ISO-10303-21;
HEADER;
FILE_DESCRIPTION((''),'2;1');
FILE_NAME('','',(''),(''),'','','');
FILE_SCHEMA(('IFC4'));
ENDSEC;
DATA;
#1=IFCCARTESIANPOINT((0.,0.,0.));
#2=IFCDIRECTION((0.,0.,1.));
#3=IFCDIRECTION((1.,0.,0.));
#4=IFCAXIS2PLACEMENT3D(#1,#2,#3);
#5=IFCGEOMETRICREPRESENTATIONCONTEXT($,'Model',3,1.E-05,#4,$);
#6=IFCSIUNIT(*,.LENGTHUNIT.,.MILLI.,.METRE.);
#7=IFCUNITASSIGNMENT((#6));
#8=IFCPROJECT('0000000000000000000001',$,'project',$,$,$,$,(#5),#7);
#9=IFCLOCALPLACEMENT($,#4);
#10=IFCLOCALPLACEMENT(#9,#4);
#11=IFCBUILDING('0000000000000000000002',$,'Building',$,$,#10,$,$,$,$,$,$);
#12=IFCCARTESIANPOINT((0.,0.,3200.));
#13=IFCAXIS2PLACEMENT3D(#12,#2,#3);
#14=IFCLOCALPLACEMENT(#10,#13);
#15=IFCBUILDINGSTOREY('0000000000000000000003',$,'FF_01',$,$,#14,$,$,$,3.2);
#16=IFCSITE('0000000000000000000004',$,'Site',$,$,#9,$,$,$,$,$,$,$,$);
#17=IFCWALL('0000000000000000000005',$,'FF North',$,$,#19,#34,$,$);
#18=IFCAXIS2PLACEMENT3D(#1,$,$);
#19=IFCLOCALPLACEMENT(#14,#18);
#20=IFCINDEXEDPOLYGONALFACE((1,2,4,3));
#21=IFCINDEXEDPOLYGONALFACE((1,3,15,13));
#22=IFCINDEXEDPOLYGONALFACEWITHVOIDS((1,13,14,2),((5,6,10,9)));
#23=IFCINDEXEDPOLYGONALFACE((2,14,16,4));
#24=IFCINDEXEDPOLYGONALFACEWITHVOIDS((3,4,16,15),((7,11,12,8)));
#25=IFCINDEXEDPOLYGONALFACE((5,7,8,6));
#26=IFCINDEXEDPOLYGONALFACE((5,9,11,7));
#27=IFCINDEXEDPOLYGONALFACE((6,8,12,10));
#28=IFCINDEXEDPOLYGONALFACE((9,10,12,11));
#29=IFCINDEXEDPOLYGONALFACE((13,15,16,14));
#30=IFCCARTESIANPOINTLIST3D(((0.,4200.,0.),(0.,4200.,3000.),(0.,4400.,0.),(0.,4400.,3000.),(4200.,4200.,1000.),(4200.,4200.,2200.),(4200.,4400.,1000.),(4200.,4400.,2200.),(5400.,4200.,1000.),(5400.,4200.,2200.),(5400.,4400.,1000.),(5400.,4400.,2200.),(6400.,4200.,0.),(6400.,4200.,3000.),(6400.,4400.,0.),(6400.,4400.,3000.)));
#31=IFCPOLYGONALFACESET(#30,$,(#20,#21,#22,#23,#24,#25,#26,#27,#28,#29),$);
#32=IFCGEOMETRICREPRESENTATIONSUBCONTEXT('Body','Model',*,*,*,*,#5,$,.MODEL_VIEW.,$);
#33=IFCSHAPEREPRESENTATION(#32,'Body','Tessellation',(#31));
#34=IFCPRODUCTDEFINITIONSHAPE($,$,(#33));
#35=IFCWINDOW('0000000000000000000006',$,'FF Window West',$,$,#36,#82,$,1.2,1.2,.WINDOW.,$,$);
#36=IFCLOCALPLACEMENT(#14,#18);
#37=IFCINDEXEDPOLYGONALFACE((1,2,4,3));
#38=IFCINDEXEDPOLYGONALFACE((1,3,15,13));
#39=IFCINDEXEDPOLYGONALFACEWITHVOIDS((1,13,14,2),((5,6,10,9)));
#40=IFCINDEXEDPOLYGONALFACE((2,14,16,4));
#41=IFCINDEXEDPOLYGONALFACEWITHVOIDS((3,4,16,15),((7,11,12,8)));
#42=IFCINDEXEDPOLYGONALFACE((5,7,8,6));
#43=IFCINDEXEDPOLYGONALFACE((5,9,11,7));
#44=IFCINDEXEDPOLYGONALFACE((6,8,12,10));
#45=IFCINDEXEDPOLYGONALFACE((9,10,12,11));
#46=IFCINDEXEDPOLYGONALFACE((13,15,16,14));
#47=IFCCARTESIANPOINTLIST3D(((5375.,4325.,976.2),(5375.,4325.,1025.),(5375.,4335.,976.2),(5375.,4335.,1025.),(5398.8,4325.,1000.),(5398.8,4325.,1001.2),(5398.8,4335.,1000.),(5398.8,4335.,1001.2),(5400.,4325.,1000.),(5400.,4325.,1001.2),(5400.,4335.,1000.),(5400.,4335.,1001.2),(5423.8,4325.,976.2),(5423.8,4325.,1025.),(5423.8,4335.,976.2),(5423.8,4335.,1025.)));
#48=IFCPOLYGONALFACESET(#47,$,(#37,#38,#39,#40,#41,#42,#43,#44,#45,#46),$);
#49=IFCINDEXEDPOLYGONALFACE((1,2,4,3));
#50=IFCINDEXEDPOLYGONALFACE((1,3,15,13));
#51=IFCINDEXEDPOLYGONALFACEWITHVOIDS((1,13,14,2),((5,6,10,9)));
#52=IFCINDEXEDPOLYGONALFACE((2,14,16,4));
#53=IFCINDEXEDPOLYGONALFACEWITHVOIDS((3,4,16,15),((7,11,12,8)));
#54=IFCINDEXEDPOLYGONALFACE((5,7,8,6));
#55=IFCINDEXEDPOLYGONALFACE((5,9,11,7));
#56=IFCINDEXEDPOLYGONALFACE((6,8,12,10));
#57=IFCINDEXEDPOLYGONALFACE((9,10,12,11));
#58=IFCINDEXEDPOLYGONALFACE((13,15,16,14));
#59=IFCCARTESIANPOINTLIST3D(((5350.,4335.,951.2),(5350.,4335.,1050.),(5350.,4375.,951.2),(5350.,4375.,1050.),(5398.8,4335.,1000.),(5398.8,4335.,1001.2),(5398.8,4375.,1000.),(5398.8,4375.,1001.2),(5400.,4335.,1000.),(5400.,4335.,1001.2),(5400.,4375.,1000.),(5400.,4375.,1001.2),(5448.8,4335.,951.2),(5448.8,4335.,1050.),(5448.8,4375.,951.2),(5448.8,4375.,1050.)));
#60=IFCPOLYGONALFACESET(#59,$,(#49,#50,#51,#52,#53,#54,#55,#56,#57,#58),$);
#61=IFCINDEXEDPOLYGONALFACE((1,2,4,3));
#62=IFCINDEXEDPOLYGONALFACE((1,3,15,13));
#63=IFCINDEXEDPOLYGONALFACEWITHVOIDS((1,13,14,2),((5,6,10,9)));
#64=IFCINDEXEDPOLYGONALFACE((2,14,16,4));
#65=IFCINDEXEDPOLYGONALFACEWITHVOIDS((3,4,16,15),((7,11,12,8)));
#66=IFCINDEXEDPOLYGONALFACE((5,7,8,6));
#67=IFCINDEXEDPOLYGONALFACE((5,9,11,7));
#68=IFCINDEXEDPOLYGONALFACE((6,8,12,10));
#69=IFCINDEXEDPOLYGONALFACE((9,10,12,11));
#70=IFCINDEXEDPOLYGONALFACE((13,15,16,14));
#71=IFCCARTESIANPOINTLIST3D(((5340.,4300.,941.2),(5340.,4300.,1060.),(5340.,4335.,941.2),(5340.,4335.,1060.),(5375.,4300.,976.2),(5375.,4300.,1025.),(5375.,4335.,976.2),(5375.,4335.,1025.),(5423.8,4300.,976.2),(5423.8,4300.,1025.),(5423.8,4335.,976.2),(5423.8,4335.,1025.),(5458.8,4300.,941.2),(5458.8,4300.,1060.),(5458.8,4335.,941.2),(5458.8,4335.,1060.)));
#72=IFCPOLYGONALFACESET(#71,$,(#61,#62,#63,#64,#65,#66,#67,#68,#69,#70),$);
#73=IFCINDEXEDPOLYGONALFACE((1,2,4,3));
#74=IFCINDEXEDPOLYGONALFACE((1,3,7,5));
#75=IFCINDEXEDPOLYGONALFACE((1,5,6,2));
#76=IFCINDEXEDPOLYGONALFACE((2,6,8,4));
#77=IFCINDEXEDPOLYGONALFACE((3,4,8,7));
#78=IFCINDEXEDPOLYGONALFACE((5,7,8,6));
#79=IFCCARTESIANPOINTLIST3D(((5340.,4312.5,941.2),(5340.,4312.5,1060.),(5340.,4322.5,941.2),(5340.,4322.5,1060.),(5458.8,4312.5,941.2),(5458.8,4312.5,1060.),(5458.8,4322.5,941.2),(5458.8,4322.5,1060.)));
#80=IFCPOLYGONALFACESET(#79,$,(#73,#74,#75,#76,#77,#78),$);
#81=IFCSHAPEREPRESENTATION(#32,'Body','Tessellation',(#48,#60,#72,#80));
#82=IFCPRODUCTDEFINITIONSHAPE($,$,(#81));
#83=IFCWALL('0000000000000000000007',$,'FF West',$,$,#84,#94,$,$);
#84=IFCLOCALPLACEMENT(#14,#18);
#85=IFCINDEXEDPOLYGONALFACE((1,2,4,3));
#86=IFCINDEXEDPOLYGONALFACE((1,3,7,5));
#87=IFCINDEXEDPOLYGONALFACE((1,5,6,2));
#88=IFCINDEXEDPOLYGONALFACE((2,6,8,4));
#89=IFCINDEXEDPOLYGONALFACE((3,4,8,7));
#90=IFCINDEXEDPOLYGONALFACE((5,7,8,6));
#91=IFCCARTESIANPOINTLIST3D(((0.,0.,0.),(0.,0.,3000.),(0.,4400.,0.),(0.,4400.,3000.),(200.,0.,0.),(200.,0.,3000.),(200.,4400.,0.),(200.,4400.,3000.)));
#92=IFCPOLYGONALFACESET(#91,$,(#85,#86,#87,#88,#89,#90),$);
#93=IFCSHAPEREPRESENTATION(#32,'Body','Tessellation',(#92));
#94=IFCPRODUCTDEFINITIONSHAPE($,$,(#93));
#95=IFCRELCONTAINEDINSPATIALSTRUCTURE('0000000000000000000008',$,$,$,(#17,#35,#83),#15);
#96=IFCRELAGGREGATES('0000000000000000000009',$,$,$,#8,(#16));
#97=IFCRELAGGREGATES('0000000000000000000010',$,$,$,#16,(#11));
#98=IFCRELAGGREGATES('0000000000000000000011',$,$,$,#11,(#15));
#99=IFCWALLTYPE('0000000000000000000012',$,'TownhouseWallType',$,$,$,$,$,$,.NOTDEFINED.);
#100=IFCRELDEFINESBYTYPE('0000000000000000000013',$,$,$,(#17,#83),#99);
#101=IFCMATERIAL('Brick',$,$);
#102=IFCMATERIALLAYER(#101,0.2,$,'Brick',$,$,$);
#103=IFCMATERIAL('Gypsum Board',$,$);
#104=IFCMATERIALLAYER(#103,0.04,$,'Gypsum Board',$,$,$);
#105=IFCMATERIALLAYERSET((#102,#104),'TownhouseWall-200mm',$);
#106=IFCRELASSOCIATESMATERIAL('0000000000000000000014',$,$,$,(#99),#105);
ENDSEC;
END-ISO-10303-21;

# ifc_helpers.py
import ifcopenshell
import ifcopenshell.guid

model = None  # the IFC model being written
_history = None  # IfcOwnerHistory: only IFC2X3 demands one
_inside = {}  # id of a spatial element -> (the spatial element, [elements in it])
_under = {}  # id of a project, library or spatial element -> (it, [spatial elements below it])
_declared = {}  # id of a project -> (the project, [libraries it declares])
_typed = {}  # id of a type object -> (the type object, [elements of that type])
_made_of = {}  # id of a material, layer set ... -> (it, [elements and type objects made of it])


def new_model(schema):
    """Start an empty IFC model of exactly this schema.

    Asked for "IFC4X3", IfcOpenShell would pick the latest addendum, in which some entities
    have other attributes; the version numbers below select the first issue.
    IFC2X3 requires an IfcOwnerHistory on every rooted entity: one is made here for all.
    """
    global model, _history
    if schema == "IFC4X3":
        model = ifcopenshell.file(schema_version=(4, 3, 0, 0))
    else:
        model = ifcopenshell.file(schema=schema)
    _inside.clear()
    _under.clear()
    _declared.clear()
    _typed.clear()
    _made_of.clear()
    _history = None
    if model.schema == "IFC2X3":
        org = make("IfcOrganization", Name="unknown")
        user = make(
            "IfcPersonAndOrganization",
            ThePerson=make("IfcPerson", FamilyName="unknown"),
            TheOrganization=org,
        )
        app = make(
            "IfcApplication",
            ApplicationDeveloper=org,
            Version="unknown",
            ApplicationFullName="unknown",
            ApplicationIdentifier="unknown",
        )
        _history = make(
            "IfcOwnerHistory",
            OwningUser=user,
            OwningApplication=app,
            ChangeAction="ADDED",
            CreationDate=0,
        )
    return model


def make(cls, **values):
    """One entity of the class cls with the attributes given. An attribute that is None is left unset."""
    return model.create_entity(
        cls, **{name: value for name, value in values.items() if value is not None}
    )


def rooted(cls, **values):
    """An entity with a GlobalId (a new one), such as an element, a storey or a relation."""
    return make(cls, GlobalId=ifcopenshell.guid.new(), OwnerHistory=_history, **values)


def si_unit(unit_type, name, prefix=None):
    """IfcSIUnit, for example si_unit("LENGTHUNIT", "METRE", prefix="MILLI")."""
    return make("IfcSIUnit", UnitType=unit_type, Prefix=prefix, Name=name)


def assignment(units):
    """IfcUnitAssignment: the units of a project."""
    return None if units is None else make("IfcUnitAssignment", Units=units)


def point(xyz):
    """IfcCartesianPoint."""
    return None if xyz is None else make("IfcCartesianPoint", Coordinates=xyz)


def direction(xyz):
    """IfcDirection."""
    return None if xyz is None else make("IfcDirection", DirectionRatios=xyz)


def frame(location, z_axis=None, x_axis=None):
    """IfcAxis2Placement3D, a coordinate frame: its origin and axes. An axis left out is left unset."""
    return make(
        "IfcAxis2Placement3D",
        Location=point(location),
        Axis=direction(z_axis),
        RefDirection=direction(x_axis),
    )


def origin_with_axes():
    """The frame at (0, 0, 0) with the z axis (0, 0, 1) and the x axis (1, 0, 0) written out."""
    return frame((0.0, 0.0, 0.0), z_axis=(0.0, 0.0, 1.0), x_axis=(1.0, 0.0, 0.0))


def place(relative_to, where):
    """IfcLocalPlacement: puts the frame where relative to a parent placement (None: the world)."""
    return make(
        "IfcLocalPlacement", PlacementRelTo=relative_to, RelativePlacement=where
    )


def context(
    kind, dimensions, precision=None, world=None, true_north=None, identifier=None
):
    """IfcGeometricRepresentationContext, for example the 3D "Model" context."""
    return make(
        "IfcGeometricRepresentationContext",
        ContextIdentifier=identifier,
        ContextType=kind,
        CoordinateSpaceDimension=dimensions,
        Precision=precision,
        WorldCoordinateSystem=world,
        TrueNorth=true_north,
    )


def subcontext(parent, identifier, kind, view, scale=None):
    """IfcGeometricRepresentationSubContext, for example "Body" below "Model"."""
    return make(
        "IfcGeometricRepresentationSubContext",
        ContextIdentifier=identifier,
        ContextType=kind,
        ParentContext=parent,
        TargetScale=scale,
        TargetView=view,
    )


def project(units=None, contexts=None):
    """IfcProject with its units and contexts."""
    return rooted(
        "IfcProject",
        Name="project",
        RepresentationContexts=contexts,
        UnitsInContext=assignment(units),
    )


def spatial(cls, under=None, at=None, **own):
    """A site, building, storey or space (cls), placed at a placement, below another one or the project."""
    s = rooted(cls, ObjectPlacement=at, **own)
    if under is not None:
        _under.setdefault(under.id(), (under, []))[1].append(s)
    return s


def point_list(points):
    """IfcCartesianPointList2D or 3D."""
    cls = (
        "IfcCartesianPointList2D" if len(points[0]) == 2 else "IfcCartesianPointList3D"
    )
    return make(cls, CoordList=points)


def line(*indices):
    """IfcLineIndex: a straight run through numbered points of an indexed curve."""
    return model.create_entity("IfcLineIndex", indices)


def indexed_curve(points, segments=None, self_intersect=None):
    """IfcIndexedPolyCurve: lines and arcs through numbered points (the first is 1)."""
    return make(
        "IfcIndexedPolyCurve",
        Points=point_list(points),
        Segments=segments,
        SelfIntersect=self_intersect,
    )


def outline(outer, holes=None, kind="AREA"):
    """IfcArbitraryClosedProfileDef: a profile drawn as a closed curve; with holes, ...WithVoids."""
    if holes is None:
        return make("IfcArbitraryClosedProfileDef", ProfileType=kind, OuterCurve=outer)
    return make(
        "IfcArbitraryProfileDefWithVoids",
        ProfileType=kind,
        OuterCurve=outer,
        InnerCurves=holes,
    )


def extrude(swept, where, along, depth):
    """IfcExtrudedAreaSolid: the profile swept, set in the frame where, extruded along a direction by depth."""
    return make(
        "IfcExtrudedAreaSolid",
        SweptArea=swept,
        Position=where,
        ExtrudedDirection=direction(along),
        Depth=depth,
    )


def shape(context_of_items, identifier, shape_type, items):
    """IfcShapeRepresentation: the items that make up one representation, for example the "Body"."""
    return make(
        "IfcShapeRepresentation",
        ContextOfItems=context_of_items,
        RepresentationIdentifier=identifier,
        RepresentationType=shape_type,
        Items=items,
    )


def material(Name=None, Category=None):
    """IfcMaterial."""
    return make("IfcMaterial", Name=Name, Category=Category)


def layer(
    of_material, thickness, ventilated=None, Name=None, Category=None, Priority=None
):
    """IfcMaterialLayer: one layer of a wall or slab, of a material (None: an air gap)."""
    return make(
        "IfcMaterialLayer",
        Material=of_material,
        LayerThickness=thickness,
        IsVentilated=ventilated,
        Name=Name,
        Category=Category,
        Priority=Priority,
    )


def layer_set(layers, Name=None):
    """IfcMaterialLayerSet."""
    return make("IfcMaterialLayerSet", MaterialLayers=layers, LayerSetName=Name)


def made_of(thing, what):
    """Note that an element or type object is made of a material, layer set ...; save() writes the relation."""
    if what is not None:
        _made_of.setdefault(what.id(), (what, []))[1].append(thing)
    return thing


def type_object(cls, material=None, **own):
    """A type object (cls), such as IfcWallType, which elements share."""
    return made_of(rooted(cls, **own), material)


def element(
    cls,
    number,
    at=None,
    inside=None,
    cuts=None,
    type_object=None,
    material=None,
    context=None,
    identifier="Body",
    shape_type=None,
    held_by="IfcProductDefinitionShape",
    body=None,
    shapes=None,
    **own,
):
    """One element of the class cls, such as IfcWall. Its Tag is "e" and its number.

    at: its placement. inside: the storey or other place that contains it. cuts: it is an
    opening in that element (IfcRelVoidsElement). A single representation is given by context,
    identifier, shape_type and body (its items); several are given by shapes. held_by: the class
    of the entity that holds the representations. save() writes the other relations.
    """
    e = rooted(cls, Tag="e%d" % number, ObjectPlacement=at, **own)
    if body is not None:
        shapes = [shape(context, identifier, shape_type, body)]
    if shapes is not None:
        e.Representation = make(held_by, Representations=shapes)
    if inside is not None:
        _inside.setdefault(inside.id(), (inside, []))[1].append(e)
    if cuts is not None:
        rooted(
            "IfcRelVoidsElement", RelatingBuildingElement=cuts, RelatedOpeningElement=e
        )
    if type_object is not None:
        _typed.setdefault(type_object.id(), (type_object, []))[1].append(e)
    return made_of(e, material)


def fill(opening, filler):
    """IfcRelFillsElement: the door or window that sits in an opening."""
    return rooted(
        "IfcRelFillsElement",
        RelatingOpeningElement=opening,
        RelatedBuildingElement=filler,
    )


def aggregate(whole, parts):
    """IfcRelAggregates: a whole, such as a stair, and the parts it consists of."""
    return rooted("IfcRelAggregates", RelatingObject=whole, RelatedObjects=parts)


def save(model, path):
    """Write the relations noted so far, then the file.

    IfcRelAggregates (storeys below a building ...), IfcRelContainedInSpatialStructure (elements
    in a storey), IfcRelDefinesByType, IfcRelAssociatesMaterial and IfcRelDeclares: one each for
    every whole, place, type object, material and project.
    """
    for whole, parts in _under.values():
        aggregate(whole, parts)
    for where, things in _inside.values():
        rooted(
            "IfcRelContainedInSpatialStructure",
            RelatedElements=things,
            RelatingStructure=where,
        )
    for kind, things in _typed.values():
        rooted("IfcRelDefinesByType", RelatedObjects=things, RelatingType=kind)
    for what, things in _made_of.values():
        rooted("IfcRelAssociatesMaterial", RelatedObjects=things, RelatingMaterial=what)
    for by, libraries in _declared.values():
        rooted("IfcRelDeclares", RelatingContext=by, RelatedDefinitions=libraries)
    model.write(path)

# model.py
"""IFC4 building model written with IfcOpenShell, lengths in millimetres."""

from ifc_helpers import new_model, si_unit, frame, origin_with_axes, place, context, subcontext, project, spatial, line, indexed_curve, outline, extrude, material, layer, layer_set, type_object, element, fill, save


model = new_model("IFC4")

# Units and contexts
model_context = context("Model", 3, precision=1e-05, world=origin_with_axes())
body_context = subcontext(model_context, "Body", "Model", "MODEL_VIEW")
ifc_project = project(units=[si_unit("LENGTHUNIT", "METRE", prefix="MILLI")], contexts=[model_context])

# Site, building, storey
site_placement = place(None, origin_with_axes())
site = spatial("IfcSite", under=ifc_project, at=site_placement, Name="Site")
building_placement = place(site_placement, origin_with_axes())
building = spatial("IfcBuilding", under=site, at=building_placement, Name="Building")
storey_placement = place(building_placement, frame((0.0, 0.0, 3200.0), z_axis=(0.0, 0.0, 1.0), x_axis=(1.0, 0.0, 0.0)))
storey = spatial("IfcBuildingStorey", under=building, at=storey_placement, Name="FF_01", Elevation=3.2)

# Shared definitions
ifc_material_1 = material(Name="Brick")
ifc_layer_1 = layer(ifc_material_1, 0.2, Name="Brick")
ifc_material_2 = material(Name="Gypsum Board")
ifc_layer_2 = layer(ifc_material_2, 0.04, Name="Gypsum Board")
ifc_layer_set_1 = layer_set([ifc_layer_1, ifc_layer_2], Name="TownhouseWall-200mm")
wall_type = type_object("IfcWallType", Name="TownhouseWallType", PredefinedType="NOTDEFINED", material=ifc_layer_set_1)

# Wall, opening, window
wall_1_placement = place(storey_placement, frame((6400.0, 4400.0, 0.0), z_axis=(0.0, 0.0, 1.0), x_axis=(-1.0, 0.0, 0.0)))
wall_1 = element("IfcWall", 1, at=wall_1_placement, inside=storey, type_object=wall_type, Name="FF North", context=body_context, shape_type="SweptSolid", body=[
    extrude(outline(indexed_curve([(0.0, 0.0), (0.0, 200.0), (6400.0, 200.0), (6400.0, 0.0), (0.0, 0.0)], self_intersect=False)), origin_with_axes(), (0.0, 0.0, 1.0), 3000.0),
])
opening_1_placement = place(wall_1_placement, frame((1000.0, -25.0, 1000.0), z_axis=(0.0, 0.0, 1.0), x_axis=(1.0, 0.0, 0.0)))
opening_1 = element("IfcOpeningElement", 2, at=opening_1_placement, cuts=wall_1, context=body_context, shape_type="SweptSolid", body=[
    extrude(outline(indexed_curve([(0.0, 0.0), (0.0, 250.0), (1200.0, 250.0), (1200.0, 0.0), (0.0, 0.0)], self_intersect=False)), origin_with_axes(), (0.0, 0.0, 1.0), 1200.0),
])
window_1_placement = place(storey_placement, frame((5400.0, 4425.0, 1000.0), z_axis=(0.0, 0.0, 1.0), x_axis=(-1.0, 0.0, 0.0)))
window_1 = element("IfcWindow", 3, at=window_1_placement, inside=storey, Name="FF Window West", OverallHeight=1.2, OverallWidth=1.2, PredefinedType="WINDOW", context=body_context, shape_type="SweptSolid", body=[
    extrude(outline(indexed_curve([(0.0, 0.0), (1.2, 0.0), (1.2, 1.2), (0.0, 1.2)], segments=[line(1, 2, 3, 4, 1)]), holes=[indexed_curve([(25.0, 25.0), (-23.8, 25.0), (-23.8, -23.8), (25.0, -23.8)], segments=[line(1, 2, 3, 4, 1)])]), frame((0.0, 90.0, 0.0), z_axis=(0.0, -1.0, 0.0), x_axis=(1.0, 0.0, 0.0)), (0.0, 0.0, -1.0), 10.0),
    extrude(outline(indexed_curve([(0.0, 0.0), (1.2, 0.0), (1.2, 1.2), (0.0, 1.2)], segments=[line(1, 2, 3, 4, 1)]), holes=[indexed_curve([(50.0, 50.0), (-48.8, 50.0), (-48.8, -48.8), (50.0, -48.8)], segments=[line(1, 2, 3, 4, 1)])]), frame((0.0, 50.0, 0.0), z_axis=(0.0, -1.0, 0.0), x_axis=(1.0, 0.0, 0.0)), (0.0, 0.0, -1.0), 40.0),
    extrude(outline(indexed_curve([(0.0, 0.0), (-48.8, 0.0), (-48.8, -48.8), (0.0, -48.8)], segments=[line(1, 2, 3, 4, 1)]), holes=[indexed_curve([(35.0, 35.0), (-83.8, 35.0), (-83.8, -83.8), (35.0, -83.8)], segments=[line(1, 2, 3, 4, 1)])]), frame((25.0, 90.0, 25.0), z_axis=(0.0, -1.0, 0.0), x_axis=(1.0, 0.0, 0.0)), (0.0, 0.0, -1.0), 35.0),
    extrude(outline(indexed_curve([(35.0, 35.0), (-83.8, 35.0), (-83.8, -83.8), (35.0, -83.8)], segments=[line(1, 2, 3, 4, 1)])), frame((25.0, 102.5, 25.0), z_axis=(0.0, -1.0, 0.0), x_axis=(1.0, 0.0, 0.0)), (0.0, 0.0, -1.0), 10.0),
])
fill(opening_1, window_1)

# Wall
wall_2_placement = place(storey_placement, frame((0.0, 4400.0, 0.0), z_axis=(0.0, 0.0, 1.0), x_axis=(0.0, -1.0, 0.0)))
element("IfcWall", 4, at=wall_2_placement, inside=storey, type_object=wall_type, Name="FF West", context=body_context, shape_type="SweptSolid", body=[
    extrude(outline(indexed_curve([(0.0, 0.0), (0.0, 200.0), (4400.0, 200.0), (4400.0, 0.0), (0.0, 0.0)], self_intersect=False)), origin_with_axes(), (0.0, 0.0, 1.0), 3000.0),
])

save(model, "model.ifc")
